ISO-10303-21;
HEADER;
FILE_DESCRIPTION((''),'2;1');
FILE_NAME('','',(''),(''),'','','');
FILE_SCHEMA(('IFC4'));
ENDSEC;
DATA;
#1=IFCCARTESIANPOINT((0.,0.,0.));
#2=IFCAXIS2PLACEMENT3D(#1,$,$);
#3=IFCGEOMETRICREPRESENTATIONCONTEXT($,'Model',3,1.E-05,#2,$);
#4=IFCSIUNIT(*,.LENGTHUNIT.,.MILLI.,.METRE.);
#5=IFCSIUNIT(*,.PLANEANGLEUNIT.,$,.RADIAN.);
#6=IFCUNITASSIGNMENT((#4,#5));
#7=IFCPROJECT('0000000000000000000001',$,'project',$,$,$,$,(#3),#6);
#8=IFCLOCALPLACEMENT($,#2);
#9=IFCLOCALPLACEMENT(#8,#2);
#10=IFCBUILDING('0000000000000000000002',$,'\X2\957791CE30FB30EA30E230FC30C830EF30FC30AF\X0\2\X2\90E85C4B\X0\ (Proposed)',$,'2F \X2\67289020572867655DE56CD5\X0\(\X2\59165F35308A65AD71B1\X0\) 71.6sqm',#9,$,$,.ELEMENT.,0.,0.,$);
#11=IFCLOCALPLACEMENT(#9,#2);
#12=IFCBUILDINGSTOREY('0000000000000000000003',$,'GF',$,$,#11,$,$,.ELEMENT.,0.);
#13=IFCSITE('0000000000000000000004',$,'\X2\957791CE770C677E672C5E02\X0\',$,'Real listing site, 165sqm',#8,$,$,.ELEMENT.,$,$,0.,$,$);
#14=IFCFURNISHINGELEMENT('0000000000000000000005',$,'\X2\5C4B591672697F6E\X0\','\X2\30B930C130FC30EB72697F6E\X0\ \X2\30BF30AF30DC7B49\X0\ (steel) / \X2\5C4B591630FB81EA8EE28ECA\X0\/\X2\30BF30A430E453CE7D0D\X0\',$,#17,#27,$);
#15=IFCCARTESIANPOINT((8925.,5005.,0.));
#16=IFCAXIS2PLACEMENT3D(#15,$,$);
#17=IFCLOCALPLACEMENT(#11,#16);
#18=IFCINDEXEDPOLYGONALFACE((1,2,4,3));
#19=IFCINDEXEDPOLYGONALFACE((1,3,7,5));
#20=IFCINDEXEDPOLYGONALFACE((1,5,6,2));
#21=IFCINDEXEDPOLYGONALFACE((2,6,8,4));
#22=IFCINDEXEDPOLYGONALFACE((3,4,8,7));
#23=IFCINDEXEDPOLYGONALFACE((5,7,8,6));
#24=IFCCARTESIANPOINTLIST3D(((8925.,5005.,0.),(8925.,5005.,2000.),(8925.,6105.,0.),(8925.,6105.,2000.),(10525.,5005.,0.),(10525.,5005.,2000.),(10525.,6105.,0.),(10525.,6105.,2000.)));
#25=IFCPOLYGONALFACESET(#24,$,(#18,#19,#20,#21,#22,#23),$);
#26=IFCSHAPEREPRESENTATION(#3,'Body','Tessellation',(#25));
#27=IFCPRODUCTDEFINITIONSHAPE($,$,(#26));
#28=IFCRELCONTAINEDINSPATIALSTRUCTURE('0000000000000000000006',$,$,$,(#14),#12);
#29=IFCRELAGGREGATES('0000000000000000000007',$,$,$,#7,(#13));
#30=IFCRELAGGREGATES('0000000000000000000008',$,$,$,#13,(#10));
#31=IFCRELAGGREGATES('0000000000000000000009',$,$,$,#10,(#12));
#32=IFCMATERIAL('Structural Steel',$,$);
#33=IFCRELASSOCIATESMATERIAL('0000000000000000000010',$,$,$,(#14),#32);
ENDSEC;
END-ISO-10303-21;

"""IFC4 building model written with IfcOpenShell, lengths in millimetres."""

from ifc_helpers import new_model, si_unit, frame, frame_2d, origin, place, context, project, spatial, rectangle, extrude, material, element, save


model = new_model("IFC4")

# Units and contexts
model_context = context("Model", 3, precision=1e-05, world=origin())
ifc_project = project(units=[si_unit("LENGTHUNIT", "METRE", prefix="MILLI"), si_unit("PLANEANGLEUNIT", "RADIAN")], contexts=[model_context])

# Site, building, storey
site_placement = place(None, origin())
site = spatial("IfcSite", under=ifc_project, at=site_placement, Name="長野県松本市", ObjectType="Real listing site, 165sqm", CompositionType="ELEMENT", RefElevation=0.0)
building_placement = place(site_placement, origin())
building = spatial("IfcBuilding", under=site, at=building_placement, Name="長野・リモートワーク2部屋 (Proposed)", ObjectType="2F 木造在来工法(外張り断熱) 71.6sqm", CompositionType="ELEMENT", ElevationOfRefHeight=0.0, ElevationOfTerrain=0.0)
storey_placement = place(building_placement, origin())
storey = spatial("IfcBuildingStorey", under=building, at=storey_placement, Name="GF", CompositionType="ELEMENT", Elevation=0.0)

# Shared definitions
ifc_material_1 = material(Name="Structural Steel")

# Furnishing element
furnishing_1_placement = place(storey_placement, frame((8925.0, 5005.0, 0.0)))
element("IfcFurnishingElement", 1, at=furnishing_1_placement, inside=storey, material=ifc_material_1, Name="屋外物置", Description="スチール物置 タクボ等 (steel) / 屋外・自転車/タイヤ収納", context=model_context, shape_type="SweptSolid", body=[
    extrude(rectangle(XDim=1600.0, YDim=1100.0, at=frame_2d((800.0, 550.0))), frame((8925.0, 5005.0, 0.0)), (0.0, 0.0, 1.0), 2000.0),
])

save(model, "model.ifc")
